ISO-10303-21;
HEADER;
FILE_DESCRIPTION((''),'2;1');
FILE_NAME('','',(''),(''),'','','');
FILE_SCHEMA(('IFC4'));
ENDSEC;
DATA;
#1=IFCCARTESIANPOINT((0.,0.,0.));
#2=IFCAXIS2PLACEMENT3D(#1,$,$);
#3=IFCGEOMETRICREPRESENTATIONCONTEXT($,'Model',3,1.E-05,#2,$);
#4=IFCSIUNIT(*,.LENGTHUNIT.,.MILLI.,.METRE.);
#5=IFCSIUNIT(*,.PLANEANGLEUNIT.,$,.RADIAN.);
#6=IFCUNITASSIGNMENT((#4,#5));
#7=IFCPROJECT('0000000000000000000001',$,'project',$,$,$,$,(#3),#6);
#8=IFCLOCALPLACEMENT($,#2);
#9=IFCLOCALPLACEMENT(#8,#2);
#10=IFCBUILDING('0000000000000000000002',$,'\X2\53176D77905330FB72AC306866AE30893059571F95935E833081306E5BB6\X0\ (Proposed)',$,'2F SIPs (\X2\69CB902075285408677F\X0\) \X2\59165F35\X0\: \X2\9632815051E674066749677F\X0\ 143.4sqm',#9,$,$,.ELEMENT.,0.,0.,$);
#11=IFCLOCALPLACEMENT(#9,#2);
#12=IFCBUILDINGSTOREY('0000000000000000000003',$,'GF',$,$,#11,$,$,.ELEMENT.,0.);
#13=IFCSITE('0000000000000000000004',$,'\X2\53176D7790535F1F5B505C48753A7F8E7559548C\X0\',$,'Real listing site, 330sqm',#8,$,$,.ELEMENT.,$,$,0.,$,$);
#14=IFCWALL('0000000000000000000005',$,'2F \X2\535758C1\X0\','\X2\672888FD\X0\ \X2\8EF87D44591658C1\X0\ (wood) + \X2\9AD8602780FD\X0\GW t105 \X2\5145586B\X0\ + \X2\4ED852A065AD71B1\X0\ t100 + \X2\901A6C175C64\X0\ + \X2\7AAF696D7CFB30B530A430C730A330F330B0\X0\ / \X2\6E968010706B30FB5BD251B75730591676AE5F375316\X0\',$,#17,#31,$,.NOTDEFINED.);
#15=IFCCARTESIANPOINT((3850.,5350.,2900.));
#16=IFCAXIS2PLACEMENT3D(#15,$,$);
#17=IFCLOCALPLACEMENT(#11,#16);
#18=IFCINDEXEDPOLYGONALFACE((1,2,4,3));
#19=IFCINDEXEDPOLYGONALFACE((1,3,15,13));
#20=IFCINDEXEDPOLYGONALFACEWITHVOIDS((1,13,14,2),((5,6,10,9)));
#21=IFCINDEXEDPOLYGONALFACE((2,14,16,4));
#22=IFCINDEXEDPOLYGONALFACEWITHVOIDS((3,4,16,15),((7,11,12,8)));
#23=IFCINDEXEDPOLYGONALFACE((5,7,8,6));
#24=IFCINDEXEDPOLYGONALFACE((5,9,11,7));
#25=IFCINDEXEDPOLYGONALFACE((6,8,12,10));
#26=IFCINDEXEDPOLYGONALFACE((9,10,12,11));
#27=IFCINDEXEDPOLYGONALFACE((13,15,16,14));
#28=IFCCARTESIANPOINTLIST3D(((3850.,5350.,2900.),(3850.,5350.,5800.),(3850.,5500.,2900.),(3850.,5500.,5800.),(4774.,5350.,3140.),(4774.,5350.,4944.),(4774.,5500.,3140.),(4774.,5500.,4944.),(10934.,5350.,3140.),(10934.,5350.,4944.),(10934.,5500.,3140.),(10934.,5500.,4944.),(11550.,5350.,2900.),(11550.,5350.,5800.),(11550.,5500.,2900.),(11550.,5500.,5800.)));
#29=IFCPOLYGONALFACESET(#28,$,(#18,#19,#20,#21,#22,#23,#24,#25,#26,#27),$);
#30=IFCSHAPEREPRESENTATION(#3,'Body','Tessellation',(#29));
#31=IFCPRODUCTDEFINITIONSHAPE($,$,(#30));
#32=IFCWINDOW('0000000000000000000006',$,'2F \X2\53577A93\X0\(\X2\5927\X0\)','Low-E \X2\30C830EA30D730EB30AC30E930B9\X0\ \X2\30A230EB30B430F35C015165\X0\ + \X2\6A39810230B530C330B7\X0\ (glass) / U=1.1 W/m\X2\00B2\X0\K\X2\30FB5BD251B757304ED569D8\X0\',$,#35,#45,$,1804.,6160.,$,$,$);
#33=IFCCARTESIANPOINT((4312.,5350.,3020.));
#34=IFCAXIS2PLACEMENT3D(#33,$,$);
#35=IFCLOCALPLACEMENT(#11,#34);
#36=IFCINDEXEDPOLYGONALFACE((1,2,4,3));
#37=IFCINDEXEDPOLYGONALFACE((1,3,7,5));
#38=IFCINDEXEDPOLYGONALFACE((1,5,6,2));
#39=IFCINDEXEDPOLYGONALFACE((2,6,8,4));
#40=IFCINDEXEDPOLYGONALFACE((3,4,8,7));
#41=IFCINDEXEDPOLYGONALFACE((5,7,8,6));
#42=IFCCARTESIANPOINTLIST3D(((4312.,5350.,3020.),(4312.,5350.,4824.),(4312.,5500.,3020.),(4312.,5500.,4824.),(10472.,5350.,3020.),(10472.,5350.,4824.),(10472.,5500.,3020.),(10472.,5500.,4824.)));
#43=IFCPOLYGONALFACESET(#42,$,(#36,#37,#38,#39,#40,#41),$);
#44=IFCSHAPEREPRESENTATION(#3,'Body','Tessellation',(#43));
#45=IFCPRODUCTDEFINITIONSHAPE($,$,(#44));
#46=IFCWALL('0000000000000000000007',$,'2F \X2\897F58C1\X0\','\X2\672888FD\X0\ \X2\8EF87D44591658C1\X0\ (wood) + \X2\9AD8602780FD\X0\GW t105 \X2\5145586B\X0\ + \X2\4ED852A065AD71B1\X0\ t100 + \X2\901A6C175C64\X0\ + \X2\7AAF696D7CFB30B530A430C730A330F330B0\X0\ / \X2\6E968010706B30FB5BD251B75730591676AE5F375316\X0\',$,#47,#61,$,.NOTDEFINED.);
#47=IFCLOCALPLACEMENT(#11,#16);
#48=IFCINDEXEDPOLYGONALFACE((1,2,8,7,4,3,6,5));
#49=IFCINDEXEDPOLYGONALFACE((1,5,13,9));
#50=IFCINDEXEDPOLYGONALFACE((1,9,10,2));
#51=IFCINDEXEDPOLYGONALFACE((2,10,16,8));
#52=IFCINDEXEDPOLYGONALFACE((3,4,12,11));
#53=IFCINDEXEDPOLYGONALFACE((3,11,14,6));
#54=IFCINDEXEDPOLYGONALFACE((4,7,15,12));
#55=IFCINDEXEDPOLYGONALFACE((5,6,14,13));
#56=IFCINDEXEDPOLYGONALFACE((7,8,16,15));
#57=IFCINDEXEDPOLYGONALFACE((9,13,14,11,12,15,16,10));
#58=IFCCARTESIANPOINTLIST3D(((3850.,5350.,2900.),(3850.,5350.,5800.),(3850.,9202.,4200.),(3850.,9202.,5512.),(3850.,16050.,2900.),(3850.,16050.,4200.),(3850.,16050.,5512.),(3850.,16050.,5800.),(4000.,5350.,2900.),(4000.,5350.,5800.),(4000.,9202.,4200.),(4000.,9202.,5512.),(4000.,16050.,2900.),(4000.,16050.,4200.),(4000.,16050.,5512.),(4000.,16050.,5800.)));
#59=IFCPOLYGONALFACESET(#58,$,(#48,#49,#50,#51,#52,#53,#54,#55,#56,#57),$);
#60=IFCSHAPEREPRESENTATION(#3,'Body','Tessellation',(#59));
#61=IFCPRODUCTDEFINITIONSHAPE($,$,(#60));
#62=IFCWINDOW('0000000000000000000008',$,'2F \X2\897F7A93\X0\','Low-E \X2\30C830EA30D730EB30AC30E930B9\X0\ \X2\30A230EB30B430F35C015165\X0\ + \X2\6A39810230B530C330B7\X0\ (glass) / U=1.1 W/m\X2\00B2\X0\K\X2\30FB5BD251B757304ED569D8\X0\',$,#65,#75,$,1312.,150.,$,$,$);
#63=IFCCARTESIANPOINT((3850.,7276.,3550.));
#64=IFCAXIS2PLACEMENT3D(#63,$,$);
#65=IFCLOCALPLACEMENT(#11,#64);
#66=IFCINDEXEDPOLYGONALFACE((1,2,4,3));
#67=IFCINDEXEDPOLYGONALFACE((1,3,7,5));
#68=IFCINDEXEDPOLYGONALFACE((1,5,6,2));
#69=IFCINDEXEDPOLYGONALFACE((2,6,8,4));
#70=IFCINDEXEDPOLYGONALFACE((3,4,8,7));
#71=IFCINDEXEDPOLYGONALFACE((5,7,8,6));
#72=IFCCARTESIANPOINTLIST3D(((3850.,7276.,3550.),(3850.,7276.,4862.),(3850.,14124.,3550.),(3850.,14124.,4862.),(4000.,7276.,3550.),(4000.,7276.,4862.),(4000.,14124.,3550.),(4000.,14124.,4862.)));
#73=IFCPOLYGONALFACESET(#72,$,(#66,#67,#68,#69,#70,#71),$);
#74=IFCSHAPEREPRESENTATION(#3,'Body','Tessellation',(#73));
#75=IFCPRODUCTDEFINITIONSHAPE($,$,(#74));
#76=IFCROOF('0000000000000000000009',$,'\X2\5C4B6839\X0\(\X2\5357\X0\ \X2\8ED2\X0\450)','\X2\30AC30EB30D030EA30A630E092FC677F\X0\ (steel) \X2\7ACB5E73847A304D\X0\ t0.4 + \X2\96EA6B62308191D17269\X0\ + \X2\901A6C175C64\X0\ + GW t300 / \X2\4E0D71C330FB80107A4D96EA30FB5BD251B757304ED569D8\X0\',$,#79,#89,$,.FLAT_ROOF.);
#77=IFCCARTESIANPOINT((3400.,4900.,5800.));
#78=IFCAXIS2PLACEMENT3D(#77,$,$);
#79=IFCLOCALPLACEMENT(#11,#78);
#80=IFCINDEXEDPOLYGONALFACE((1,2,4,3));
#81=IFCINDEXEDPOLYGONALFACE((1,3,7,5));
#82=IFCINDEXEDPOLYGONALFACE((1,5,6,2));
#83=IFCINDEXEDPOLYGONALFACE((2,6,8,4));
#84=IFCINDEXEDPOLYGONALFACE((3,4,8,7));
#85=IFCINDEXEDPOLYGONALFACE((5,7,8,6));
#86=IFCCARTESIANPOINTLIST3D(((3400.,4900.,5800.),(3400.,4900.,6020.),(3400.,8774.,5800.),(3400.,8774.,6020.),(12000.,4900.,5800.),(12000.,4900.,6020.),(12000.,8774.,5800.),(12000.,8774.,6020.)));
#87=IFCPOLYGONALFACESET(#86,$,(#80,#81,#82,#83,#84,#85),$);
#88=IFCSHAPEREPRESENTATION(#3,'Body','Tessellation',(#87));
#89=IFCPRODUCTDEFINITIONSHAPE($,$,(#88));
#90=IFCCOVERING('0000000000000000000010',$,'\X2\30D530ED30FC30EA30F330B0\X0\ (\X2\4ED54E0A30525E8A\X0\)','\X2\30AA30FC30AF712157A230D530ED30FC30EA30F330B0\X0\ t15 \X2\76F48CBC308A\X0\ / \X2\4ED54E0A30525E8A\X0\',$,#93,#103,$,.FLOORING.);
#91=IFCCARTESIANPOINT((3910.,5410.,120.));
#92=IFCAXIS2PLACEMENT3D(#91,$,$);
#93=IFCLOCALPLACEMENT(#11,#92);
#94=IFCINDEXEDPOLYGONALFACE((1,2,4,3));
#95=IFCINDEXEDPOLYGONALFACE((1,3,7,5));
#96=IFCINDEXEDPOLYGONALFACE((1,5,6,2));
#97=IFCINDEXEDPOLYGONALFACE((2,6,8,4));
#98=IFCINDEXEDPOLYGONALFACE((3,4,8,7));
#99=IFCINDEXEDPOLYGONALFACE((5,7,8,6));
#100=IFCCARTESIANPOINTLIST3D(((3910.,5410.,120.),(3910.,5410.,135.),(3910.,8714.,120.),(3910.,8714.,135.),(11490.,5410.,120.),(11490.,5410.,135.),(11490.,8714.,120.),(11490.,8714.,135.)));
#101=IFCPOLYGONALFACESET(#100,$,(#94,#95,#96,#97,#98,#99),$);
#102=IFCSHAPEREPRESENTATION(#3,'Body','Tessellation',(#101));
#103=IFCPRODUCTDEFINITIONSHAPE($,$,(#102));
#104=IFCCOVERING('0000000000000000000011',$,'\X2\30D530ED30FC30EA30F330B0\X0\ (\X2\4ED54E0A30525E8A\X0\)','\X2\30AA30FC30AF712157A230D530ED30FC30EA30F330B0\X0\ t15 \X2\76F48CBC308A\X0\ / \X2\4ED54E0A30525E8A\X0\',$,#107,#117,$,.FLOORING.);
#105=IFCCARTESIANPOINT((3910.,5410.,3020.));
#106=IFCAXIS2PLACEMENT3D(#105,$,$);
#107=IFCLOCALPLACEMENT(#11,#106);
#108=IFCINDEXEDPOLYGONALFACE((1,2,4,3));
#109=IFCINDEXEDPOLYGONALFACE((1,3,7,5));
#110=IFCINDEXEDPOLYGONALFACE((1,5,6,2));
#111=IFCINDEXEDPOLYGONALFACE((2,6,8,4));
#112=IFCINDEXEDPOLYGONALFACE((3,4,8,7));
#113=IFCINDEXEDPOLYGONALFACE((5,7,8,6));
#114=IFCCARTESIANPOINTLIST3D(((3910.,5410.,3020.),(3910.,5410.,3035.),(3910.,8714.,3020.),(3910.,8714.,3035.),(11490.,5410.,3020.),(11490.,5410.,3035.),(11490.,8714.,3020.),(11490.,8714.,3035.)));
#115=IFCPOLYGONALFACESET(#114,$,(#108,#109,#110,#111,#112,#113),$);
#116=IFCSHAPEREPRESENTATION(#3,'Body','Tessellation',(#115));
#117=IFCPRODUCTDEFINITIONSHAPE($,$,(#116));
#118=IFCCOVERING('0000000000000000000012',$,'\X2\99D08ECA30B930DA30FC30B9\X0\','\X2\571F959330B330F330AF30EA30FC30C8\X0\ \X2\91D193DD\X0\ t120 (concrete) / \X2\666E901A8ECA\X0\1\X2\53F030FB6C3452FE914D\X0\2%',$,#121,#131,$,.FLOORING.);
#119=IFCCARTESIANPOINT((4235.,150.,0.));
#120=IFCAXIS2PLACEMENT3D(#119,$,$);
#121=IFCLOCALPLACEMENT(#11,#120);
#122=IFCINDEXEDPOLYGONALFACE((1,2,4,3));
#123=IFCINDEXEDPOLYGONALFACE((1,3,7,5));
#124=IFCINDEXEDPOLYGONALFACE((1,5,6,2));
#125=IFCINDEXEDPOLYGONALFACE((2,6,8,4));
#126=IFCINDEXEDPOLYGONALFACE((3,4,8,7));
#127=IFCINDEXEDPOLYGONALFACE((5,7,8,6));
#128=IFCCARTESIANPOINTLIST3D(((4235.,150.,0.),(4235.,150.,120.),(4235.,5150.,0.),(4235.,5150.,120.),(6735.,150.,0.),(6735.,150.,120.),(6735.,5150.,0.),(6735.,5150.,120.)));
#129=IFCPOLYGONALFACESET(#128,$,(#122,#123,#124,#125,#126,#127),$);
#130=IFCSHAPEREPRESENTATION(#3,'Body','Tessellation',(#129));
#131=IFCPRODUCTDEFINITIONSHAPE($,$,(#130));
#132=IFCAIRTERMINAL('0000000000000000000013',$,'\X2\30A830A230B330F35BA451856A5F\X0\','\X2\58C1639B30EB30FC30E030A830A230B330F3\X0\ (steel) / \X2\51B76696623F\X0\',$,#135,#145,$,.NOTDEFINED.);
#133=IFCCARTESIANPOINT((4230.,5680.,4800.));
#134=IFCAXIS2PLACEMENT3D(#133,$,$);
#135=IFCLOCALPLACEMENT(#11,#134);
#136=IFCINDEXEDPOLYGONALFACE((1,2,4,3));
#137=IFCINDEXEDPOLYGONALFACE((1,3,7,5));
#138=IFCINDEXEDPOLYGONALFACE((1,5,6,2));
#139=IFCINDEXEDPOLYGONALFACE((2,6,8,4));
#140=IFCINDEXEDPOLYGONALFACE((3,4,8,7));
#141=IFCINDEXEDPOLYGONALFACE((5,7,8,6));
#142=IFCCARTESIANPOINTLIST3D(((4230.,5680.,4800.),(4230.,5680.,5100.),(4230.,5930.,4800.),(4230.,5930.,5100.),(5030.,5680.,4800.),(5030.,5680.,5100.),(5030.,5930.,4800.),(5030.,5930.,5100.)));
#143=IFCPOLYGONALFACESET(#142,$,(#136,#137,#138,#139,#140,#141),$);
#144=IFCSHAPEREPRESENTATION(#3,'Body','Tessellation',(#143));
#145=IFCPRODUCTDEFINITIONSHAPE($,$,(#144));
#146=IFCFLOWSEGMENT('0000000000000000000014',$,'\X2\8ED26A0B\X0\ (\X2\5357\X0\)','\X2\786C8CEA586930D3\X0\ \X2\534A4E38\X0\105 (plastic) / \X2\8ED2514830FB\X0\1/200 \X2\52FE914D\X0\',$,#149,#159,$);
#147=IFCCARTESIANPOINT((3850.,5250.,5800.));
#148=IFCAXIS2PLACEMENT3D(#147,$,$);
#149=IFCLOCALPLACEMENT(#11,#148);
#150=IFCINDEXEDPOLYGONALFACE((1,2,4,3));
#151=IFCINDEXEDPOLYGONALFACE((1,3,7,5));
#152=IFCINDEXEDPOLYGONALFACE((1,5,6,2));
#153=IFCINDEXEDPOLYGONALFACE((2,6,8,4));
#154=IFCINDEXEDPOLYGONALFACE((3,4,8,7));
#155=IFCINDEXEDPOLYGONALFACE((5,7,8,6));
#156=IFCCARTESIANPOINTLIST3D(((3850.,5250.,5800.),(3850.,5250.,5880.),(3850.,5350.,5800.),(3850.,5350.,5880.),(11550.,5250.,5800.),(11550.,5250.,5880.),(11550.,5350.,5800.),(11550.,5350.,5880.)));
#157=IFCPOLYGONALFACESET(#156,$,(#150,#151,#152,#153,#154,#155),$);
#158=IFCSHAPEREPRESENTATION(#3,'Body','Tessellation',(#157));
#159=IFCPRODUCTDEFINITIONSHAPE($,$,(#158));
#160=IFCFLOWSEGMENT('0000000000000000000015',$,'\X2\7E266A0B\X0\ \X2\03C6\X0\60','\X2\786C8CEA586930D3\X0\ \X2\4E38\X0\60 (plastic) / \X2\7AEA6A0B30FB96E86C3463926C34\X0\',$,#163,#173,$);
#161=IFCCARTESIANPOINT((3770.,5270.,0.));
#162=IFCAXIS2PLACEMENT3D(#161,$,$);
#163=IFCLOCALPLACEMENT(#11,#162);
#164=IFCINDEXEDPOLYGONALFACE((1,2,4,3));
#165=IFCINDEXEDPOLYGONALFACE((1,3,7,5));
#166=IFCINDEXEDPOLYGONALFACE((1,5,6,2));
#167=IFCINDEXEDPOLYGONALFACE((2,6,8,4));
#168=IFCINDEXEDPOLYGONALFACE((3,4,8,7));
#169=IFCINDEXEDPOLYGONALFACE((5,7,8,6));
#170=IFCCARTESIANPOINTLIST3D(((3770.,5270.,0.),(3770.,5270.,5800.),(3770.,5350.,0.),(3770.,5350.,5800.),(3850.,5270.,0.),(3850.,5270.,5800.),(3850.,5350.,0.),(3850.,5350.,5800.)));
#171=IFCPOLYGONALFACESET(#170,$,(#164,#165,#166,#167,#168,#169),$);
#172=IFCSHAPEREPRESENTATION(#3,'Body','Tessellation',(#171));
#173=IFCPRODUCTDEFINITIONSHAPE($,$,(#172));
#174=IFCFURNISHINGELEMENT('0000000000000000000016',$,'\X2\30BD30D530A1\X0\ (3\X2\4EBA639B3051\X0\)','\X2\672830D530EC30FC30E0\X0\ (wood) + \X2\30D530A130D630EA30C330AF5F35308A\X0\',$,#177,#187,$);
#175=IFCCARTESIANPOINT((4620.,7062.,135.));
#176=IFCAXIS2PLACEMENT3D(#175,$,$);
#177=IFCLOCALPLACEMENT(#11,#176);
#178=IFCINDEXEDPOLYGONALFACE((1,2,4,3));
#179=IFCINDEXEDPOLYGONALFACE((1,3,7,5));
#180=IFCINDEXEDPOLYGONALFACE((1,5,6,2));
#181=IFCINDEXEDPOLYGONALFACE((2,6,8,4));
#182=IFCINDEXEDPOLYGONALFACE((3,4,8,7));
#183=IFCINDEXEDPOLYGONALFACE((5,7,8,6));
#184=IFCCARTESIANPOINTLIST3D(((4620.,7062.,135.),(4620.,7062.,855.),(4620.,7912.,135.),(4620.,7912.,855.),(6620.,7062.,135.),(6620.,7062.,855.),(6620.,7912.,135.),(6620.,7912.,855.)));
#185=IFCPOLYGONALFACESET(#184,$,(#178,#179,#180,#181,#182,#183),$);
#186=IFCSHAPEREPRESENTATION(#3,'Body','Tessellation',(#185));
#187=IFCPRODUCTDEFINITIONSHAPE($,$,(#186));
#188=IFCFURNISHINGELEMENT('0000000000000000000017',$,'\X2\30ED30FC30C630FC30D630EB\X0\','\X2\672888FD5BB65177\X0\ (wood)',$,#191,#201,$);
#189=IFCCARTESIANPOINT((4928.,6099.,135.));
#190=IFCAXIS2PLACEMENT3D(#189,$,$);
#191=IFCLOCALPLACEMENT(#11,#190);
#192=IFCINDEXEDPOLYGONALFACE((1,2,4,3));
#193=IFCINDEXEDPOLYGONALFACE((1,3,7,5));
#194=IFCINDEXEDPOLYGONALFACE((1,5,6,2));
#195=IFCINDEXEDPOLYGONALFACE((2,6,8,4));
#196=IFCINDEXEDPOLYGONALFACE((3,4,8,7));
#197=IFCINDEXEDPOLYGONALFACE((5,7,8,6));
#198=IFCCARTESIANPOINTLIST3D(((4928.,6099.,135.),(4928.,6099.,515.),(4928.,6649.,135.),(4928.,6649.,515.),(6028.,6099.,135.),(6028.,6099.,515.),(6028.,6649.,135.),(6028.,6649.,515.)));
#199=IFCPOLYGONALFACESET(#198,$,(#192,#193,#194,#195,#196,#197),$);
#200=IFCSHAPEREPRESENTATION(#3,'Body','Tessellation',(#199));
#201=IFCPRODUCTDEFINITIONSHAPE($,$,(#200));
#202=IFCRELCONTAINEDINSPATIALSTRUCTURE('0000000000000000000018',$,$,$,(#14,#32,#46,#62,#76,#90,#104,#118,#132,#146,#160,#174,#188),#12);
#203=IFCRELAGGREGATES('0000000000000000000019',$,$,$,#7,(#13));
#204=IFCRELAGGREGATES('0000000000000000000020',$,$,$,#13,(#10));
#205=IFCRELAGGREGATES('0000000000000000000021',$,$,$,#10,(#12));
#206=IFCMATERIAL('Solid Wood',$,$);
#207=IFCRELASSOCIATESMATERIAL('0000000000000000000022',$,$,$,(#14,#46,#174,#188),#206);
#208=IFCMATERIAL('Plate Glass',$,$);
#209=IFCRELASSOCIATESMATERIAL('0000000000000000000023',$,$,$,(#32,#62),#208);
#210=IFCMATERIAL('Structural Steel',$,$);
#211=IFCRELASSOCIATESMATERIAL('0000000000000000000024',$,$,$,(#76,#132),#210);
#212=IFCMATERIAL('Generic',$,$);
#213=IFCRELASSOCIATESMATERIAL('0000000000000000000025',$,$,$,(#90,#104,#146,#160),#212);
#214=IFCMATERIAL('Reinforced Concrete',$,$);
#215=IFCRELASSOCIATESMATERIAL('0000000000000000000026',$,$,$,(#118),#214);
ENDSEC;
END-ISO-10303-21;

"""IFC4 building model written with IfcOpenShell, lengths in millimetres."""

from ifc_helpers import new_model, si_unit, frame, frame_2d, origin, place, context, project, spatial, rectangle, extrude, material, element, fill, save


model = new_model("IFC4")

# Units and contexts
model_context = context("Model", 3, precision=1e-05, world=origin())
ifc_project = project(units=[si_unit("LENGTHUNIT", "METRE", prefix="MILLI"), si_unit("PLANEANGLEUNIT", "RADIAN")], contexts=[model_context])

# Site, building, storey
site_placement = place(None, origin())
site = spatial("IfcSite", under=ifc_project, at=site_placement, Name="北海道弟子屈町美留和", ObjectType="Real listing site, 330sqm", CompositionType="ELEMENT", RefElevation=0.0)
building_placement = place(site_placement, origin())
building = spatial("IfcBuilding", under=site, at=building_placement, Name="北海道・犬と暮らす土間広めの家 (Proposed)", ObjectType="2F SIPs (構造用合板) 外張: 防腐処理杉板 143.4sqm", CompositionType="ELEMENT", ElevationOfRefHeight=0.0, ElevationOfTerrain=0.0)
storey_placement = place(building_placement, origin())
storey = spatial("IfcBuildingStorey", under=building, at=storey_placement, Name="GF", CompositionType="ELEMENT", Elevation=0.0)

# Shared definitions
ifc_material_1 = material(Name="Solid Wood")

# Shared definitions
ifc_material_2 = material(Name="Reinforced Concrete")

# Shared definitions
ifc_material_3 = material(Name="Plate Glass")

# Walls, openings, windows
wall_1_placement = place(storey_placement, frame((3850.0, 5350.0, 2900.0)))
wall_1 = element("IfcWall", 1, at=wall_1_placement, inside=storey, material=ifc_material_1, Name="2F 南壁", Description="木製 軸組外壁 (wood) + 高性能GW t105 充填 + 付加断熱 t100 + 通気層 + 窯業系サイディング / 準耐火・寒冷地外皮強化", PredefinedType="NOTDEFINED", context=model_context, shape_type="SweptSolid", body=[
    extrude(rectangle(XDim=7700.0, YDim=150.0, at=frame_2d((3850.0, 75.0))), frame((3850.0, 5350.0, 2900.0)), (0.0, 0.0, 1.0), 2900.0),
])
opening_1_placement = place(storey_placement, frame((4312.0, 5350.0, 3020.0)))
opening_1 = element("IfcOpeningElement", 2, at=opening_1_placement, cuts=wall_1, PredefinedType="NOTDEFINED", context=model_context, shape_type="SweptSolid", body=[
    extrude(rectangle(XDim=6160.0, YDim=150.0, at=frame_2d((3080.0, 75.0))), frame((4312.0, 5350.0, 3020.0)), (0.0, 0.0, 1.0), 1804.0),
])
window_1_placement = place(storey_placement, frame((4312.0, 5350.0, 3020.0)))
window_1 = element("IfcWindow", 3, at=window_1_placement, inside=storey, material=ifc_material_3, Name="2F 南窓(大)", Description="Low-E トリプルガラス アルゴン封入 + 樹脂サッシ (glass) / U=1.1 W/m²K・寒冷地仕様", OverallHeight=1804.0, OverallWidth=6160.0, context=model_context, shape_type="SweptSolid", body=[
    extrude(rectangle(XDim=6160.0, YDim=150.0, at=frame_2d((3080.0, 75.0))), frame((4312.0, 5350.0, 3020.0)), (0.0, 0.0, 1.0), 1804.0),
])
fill(opening_1, window_1)
wall_2_placement = place(storey_placement, frame((3850.0, 5350.0, 2900.0)))
wall_2 = element("IfcWall", 4, at=wall_2_placement, inside=storey, material=ifc_material_1, Name="2F 西壁", Description="木製 軸組外壁 (wood) + 高性能GW t105 充填 + 付加断熱 t100 + 通気層 + 窯業系サイディング / 準耐火・寒冷地外皮強化", PredefinedType="NOTDEFINED", context=model_context, shape_type="SweptSolid", body=[
    extrude(rectangle(XDim=150.0, YDim=10700.0, at=frame_2d((75.0, 5350.0))), frame((3850.0, 5350.0, 2900.0)), (0.0, 0.0, 1.0), 2900.0),
])
opening_2_placement = place(storey_placement, frame((3850.0, 7276.0, 3550.0)))
opening_2 = element("IfcOpeningElement", 5, at=opening_2_placement, cuts=wall_2, PredefinedType="NOTDEFINED", context=model_context, shape_type="SweptSolid", body=[
    extrude(rectangle(XDim=150.0, YDim=6848.0, at=frame_2d((75.0, 3424.0))), frame((3850.0, 7276.0, 3550.0)), (0.0, 0.0, 1.0), 1312.0),
])
window_2_placement = place(storey_placement, frame((3850.0, 7276.0, 3550.0)))
window_2 = element("IfcWindow", 6, at=window_2_placement, inside=storey, material=ifc_material_3, Name="2F 西窓", Description="Low-E トリプルガラス アルゴン封入 + 樹脂サッシ (glass) / U=1.1 W/m²K・寒冷地仕様", OverallHeight=1312.0, OverallWidth=150.0, context=model_context, shape_type="SweptSolid", body=[
    extrude(rectangle(XDim=150.0, YDim=6848.0, at=frame_2d((75.0, 3424.0))), frame((3850.0, 7276.0, 3550.0)), (0.0, 0.0, 1.0), 1312.0),
])
fill(opening_2, window_2)

# Roof
ifc_material_4 = material(Name="Structural Steel")
for number, where, name in (
    (7, (3400.0, 4900.0, 5800.0), "屋根(南 軒450)"),
):
    element("IfcRoof", number, at=place(storey_placement, frame(where)), inside=storey, material=ifc_material_4, Name=name, Description="ガルバリウム鋼板 (steel) 立平葺き t0.4 + 雪止め金物 + 通気層 + GW t300 / 不燃・耐積雪・寒冷地仕様", PredefinedType="FLAT_ROOF", context=model_context, shape_type="SweptSolid", body=[
        extrude(rectangle(XDim=8600.0, YDim=3874.0, at=frame_2d((4300.0, 1937.0))), frame((3400.0, 4900.0, 5800.0)), (0.0, 0.0, 1.0), 220.0),
    ])

# Coverings
ifc_material_5 = material(Name="Generic")
covering_1_placement = place(storey_placement, frame((3910.0, 5410.0, 120.0)))
element("IfcCovering", 8, at=covering_1_placement, inside=storey, material=ifc_material_5, Name="フローリング (仕上げ床)", Description="オーク無垢フローリング t15 直貼り / 仕上げ床", PredefinedType="FLOORING", context=model_context, shape_type="SweptSolid", body=[
    extrude(rectangle(XDim=7580.0, YDim=3304.0, at=frame_2d((3790.0, 1652.0))), frame((3910.0, 5410.0, 120.0)), (0.0, 0.0, 1.0), 15.0),
])
covering_2_placement = place(storey_placement, frame((3910.0, 5410.0, 3020.0)))
element("IfcCovering", 9, at=covering_2_placement, inside=storey, material=ifc_material_5, Name="フローリング (仕上げ床)", Description="オーク無垢フローリング t15 直貼り / 仕上げ床", PredefinedType="FLOORING", context=model_context, shape_type="SweptSolid", body=[
    extrude(rectangle(XDim=7580.0, YDim=3304.0, at=frame_2d((3790.0, 1652.0))), frame((3910.0, 5410.0, 3020.0)), (0.0, 0.0, 1.0), 15.0),
])
covering_3_placement = place(storey_placement, frame((4235.0, 150.0, 0.0)))
element("IfcCovering", 10, at=covering_3_placement, inside=storey, material=ifc_material_2, Name="駐車スペース", Description="土間コンクリート 金鏝 t120 (concrete) / 普通車1台・水勾配2%", PredefinedType="FLOORING", context=model_context, shape_type="SweptSolid", body=[
    extrude(rectangle(XDim=2500.0, YDim=5000.0, at=frame_2d((1250.0, 2500.0))), frame((4235.0, 150.0, 0.0)), (0.0, 0.0, 1.0), 120.0),
])

# Air terminal
air_terminal_placement = place(storey_placement, frame((4230.0, 5680.0, 4800.0)))
element("IfcAirTerminal", 11, at=air_terminal_placement, inside=storey, material=ifc_material_4, Name="エアコン室内機", Description="壁掛ルームエアコン (steel) / 冷暖房", PredefinedType="NOTDEFINED", context=model_context, shape_type="SweptSolid", body=[
    extrude(rectangle(XDim=800.0, YDim=250.0, at=frame_2d((400.0, 125.0))), frame((4230.0, 5680.0, 4800.0)), (0.0, 0.0, 1.0), 300.0),
])

# Flow segments
flow_segment_1_placement = place(storey_placement, frame((3850.0, 5250.0, 5800.0)))
element("IfcFlowSegment", 12, at=flow_segment_1_placement, inside=storey, material=ifc_material_5, Name="軒樋 (南)", Description="硬質塩ビ 半丸105 (plastic) / 軒先・1/200 勾配", context=model_context, shape_type="SweptSolid", body=[
    extrude(rectangle(XDim=7700.0, YDim=100.0, at=frame_2d((3850.0, 50.0))), frame((3850.0, 5250.0, 5800.0)), (0.0, 0.0, 1.0), 80.0),
])
flow_segment_2_placement = place(storey_placement, frame((3770.0, 5270.0, 0.0)))
element("IfcFlowSegment", 13, at=flow_segment_2_placement, inside=storey, material=ifc_material_5, Name="縦樋 φ60", Description="硬質塩ビ 丸60 (plastic) / 竪樋・雨水排水", context=model_context, shape_type="SweptSolid", body=[
    extrude(rectangle(XDim=80.0, YDim=80.0, at=frame_2d((40.0, 40.0))), frame((3770.0, 5270.0, 0.0)), (0.0, 0.0, 1.0), 5800.0),
])

# Furnishing elements
furnishing_1_placement = place(storey_placement, frame((4620.0, 7062.0, 135.0)))
element("IfcFurnishingElement", 14, at=furnishing_1_placement, inside=storey, material=ifc_material_1, Name="ソファ (3人掛け)", Description="木フレーム (wood) + ファブリック張り", context=model_context, shape_type="SweptSolid", body=[
    extrude(rectangle(XDim=2000.0, YDim=850.0, at=frame_2d((1000.0, 425.0))), frame((4620.0, 7062.0, 135.0)), (0.0, 0.0, 1.0), 720.0),
])
furnishing_2_placement = place(storey_placement, frame((4928.0, 6099.0, 135.0)))
element("IfcFurnishingElement", 15, at=furnishing_2_placement, inside=storey, material=ifc_material_1, Name="ローテーブル", Description="木製家具 (wood)", context=model_context, shape_type="SweptSolid", body=[
    extrude(rectangle(XDim=1100.0, YDim=550.0, at=frame_2d((550.0, 275.0))), frame((4928.0, 6099.0, 135.0)), (0.0, 0.0, 1.0), 380.0),
])

save(model, "model.ifc")
